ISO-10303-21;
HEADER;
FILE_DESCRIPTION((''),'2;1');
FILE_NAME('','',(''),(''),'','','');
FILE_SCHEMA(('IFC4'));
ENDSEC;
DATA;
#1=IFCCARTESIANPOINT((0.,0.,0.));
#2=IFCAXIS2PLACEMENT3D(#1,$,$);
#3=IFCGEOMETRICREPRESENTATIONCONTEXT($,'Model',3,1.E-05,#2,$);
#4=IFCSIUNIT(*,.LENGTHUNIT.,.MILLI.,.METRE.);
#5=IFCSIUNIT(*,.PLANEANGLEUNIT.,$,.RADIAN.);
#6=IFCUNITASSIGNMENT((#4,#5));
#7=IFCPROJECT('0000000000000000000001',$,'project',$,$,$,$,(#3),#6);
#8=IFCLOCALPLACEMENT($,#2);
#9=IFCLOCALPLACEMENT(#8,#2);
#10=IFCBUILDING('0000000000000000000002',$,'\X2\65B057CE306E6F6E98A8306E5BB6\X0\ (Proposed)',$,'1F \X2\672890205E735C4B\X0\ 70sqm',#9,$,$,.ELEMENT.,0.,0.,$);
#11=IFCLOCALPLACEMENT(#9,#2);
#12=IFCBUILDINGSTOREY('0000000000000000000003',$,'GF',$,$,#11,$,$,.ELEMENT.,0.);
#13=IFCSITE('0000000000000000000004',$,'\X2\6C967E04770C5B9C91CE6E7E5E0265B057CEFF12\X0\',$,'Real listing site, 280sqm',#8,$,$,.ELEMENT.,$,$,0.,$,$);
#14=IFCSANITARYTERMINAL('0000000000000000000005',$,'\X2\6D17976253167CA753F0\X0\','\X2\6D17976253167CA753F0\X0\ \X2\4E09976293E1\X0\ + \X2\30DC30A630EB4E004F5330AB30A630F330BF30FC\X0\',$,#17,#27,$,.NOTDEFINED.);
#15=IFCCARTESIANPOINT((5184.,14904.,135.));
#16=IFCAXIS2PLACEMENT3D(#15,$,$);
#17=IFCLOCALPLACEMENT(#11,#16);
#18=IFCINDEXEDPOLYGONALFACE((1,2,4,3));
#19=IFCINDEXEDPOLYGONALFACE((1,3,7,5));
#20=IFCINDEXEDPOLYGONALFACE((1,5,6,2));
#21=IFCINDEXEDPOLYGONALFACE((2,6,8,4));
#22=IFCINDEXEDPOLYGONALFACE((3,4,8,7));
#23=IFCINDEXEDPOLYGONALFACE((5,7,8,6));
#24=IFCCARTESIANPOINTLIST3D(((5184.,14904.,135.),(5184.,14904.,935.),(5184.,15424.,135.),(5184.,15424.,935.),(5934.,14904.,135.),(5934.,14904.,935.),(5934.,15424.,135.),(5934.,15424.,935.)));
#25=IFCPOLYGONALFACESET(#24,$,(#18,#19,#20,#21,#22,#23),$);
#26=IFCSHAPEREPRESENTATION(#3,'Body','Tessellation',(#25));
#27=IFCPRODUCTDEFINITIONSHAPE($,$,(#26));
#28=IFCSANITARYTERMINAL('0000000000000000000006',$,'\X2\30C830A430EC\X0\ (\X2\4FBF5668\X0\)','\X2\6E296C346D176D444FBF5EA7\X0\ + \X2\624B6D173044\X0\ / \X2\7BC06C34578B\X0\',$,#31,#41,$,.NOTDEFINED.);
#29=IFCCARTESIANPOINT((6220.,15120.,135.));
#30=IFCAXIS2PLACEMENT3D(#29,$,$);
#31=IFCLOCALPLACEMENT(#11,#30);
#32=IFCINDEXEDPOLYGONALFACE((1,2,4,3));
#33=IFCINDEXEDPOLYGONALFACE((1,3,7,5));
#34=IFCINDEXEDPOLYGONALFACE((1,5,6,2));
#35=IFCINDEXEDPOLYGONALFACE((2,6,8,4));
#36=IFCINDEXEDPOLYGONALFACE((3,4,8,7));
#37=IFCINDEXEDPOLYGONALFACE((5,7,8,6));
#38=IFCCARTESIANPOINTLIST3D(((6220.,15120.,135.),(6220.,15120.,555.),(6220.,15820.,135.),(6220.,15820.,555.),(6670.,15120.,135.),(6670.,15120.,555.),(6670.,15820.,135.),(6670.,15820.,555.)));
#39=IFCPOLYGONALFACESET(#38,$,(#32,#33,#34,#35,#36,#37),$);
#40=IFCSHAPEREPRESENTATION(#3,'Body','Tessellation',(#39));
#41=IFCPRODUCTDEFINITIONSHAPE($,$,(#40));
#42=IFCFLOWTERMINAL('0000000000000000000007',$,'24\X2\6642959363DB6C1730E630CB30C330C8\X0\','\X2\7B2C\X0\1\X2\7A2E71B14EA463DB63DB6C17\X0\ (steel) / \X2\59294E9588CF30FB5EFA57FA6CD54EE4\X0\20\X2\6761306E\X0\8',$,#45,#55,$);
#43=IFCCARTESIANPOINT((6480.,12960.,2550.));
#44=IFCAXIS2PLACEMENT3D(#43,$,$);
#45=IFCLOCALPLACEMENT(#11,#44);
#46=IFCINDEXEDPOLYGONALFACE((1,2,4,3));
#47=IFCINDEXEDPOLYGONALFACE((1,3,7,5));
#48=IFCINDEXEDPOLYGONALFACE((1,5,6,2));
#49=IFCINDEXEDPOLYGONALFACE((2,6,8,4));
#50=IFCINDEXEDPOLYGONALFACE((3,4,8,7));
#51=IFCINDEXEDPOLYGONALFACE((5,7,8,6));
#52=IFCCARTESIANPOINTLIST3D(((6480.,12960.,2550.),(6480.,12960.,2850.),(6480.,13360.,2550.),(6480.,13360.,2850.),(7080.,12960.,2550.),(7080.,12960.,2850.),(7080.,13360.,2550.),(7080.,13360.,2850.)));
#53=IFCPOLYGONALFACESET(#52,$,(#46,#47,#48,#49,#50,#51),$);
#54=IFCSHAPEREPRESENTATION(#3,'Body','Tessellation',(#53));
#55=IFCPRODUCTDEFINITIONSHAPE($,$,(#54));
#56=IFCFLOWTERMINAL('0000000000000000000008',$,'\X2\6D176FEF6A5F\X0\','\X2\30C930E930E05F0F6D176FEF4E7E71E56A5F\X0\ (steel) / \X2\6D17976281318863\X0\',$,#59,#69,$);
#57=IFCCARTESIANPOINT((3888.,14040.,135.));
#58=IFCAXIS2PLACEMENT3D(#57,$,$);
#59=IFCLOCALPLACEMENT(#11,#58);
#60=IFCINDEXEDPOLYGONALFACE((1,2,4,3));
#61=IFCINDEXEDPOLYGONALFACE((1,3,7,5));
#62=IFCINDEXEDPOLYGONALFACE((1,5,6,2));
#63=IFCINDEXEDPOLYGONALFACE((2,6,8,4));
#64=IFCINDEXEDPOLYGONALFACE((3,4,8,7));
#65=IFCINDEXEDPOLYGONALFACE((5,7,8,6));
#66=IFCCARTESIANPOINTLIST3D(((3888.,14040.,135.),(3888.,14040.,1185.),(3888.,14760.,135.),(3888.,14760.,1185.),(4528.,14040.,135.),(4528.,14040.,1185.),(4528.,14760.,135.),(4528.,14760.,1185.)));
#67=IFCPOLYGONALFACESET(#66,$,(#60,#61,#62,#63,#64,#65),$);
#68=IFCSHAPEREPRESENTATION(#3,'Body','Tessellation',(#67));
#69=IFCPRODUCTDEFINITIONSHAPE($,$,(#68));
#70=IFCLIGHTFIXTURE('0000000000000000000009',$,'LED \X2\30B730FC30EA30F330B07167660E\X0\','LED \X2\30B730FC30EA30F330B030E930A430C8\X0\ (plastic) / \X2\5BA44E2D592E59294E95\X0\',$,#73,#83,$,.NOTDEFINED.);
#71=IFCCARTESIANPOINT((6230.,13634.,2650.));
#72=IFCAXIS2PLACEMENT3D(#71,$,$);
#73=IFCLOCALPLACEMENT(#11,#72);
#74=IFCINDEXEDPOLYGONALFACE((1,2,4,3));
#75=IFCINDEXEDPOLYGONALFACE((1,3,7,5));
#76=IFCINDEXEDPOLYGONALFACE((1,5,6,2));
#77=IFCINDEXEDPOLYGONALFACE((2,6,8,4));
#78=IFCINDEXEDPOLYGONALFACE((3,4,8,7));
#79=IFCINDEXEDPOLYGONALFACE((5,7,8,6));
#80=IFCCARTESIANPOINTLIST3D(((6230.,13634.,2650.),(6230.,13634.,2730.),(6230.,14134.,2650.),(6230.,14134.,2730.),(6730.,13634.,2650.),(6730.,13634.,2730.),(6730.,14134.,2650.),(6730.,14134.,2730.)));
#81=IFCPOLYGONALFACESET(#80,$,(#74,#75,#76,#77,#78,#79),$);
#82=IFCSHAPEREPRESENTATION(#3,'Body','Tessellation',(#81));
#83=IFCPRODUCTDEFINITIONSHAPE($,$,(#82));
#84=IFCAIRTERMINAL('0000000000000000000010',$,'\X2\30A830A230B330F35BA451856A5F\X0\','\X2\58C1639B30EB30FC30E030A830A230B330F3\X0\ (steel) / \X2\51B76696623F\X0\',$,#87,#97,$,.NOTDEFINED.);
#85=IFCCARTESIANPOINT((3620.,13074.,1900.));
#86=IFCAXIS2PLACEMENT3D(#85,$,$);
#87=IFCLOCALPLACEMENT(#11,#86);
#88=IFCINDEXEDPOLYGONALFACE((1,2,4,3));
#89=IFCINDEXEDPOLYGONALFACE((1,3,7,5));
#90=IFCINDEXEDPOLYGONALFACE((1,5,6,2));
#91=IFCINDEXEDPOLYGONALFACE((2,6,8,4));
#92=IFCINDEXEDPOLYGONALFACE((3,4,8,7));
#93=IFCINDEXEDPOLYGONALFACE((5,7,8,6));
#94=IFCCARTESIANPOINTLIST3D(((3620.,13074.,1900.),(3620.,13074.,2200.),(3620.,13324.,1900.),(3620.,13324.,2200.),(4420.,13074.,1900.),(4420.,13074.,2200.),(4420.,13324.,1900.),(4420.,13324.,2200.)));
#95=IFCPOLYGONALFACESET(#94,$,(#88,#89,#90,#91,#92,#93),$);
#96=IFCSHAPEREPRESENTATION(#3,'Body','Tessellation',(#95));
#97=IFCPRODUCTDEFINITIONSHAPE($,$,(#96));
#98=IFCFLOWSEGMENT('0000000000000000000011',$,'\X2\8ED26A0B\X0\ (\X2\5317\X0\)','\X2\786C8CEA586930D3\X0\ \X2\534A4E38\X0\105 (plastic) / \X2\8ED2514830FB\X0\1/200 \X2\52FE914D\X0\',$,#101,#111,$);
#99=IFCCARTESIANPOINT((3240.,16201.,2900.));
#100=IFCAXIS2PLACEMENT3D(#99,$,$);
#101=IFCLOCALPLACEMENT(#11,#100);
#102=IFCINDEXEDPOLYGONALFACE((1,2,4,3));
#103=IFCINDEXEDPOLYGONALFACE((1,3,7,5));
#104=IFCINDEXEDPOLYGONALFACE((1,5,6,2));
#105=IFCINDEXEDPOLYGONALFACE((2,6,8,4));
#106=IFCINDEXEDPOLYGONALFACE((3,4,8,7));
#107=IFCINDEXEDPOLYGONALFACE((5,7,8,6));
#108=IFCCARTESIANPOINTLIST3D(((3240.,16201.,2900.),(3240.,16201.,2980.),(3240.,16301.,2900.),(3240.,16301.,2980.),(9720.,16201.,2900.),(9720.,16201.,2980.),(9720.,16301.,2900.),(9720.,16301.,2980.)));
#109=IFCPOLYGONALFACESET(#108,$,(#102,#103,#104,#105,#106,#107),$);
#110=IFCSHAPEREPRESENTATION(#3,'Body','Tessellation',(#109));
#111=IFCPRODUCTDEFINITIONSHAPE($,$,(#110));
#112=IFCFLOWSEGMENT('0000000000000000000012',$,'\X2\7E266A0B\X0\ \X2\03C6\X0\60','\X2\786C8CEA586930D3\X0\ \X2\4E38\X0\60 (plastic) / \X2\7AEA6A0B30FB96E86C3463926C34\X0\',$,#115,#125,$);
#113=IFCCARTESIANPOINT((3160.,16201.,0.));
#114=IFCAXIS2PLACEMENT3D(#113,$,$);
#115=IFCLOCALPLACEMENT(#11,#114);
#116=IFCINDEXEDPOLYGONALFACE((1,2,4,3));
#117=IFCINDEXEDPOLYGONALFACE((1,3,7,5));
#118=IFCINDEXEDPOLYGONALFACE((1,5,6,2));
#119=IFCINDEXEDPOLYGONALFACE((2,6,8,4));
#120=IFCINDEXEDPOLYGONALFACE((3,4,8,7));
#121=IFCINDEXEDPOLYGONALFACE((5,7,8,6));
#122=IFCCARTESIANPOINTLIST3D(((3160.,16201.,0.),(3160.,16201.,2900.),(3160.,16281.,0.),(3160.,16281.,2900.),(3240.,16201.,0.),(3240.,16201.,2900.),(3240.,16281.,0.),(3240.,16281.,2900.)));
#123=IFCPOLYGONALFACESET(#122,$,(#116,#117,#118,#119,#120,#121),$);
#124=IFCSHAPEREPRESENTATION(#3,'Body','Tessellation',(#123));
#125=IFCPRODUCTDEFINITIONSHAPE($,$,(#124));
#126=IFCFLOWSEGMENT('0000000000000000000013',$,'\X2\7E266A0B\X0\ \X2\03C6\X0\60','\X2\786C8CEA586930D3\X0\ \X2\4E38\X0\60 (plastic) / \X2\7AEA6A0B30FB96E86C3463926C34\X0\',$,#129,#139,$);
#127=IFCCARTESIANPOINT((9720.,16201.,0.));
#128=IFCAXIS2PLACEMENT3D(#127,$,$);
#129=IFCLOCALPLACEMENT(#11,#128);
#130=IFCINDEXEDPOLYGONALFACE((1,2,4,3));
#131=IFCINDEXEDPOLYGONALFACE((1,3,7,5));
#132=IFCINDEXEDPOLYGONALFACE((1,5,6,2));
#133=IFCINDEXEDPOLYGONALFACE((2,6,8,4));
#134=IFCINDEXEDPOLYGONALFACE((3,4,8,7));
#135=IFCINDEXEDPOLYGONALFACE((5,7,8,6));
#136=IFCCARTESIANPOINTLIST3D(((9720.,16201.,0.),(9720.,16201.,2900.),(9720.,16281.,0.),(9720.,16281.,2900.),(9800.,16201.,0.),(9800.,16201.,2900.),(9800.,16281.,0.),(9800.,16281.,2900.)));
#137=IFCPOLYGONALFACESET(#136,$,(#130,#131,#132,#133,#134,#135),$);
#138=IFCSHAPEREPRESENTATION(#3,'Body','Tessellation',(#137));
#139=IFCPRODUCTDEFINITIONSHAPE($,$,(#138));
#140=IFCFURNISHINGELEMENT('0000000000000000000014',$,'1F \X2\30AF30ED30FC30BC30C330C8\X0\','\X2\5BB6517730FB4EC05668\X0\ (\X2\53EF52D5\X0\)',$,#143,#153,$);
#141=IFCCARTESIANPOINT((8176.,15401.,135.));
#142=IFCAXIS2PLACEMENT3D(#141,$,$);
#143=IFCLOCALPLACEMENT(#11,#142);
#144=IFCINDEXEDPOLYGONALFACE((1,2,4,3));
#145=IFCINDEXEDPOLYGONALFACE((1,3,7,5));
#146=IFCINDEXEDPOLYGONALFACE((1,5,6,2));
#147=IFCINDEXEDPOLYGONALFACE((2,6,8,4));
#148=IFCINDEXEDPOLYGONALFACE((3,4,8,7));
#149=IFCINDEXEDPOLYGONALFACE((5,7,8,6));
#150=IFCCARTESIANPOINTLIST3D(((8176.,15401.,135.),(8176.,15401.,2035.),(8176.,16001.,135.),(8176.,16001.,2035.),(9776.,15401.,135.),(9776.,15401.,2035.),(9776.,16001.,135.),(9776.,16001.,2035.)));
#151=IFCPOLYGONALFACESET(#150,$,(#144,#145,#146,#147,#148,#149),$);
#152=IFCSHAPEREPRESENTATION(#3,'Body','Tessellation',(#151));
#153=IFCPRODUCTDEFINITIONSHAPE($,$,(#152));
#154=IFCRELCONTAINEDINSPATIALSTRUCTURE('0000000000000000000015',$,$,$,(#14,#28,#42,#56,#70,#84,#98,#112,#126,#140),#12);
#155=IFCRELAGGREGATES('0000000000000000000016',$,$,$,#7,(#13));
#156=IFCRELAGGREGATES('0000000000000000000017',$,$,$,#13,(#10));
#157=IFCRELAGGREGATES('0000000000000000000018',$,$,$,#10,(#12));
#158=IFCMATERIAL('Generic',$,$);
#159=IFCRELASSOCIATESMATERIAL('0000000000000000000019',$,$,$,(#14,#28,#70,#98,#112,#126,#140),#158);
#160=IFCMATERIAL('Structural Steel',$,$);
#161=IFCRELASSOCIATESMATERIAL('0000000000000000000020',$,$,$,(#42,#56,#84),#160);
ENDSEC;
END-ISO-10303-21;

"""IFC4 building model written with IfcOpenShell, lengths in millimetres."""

from ifc_helpers import new_model, si_unit, frame, frame_2d, origin, place, context, project, spatial, rectangle, extrude, material, element, save


model = new_model("IFC4")

# Units and contexts
model_context = context("Model", 3, precision=1e-05, world=origin())
ifc_project = project(units=[si_unit("LENGTHUNIT", "METRE", prefix="MILLI"), si_unit("PLANEANGLEUNIT", "RADIAN")], contexts=[model_context])

# Site, building, storey
site_placement = place(None, origin())
site = spatial("IfcSite", under=ifc_project, at=site_placement, Name="沖縄県宜野湾市新城２", ObjectType="Real listing site, 280sqm", CompositionType="ELEMENT", RefElevation=0.0)
building_placement = place(site_placement, origin())
building = spatial("IfcBuilding", under=site, at=building_placement, Name="新城の潮風の家 (Proposed)", ObjectType="1F 木造平屋 70sqm", CompositionType="ELEMENT", ElevationOfRefHeight=0.0, ElevationOfTerrain=0.0)
storey_placement = place(building_placement, origin())
storey = spatial("IfcBuildingStorey", under=building, at=storey_placement, Name="GF", CompositionType="ELEMENT", Elevation=0.0)

# Shared definitions
ifc_material_1 = material(Name="Generic")

# Sanitary terminals
sanitary_terminal_1_placement = place(storey_placement, frame((5184.0, 14904.0, 135.0)))
element("IfcSanitaryTerminal", 1, at=sanitary_terminal_1_placement, inside=storey, material=ifc_material_1, Name="洗面化粧台", Description="洗面化粧台 三面鏡 + ボウル一体カウンター", PredefinedType="NOTDEFINED", context=model_context, shape_type="SweptSolid", body=[
    extrude(rectangle(XDim=750.0, YDim=520.0, at=frame_2d((375.0, 260.0))), frame((5184.0, 14904.0, 135.0)), (0.0, 0.0, 1.0), 800.0),
])
sanitary_terminal_2_placement = place(storey_placement, frame((6220.0, 15120.0, 135.0)))
element("IfcSanitaryTerminal", 2, at=sanitary_terminal_2_placement, inside=storey, material=ifc_material_1, Name="トイレ (便器)", Description="温水洗浄便座 + 手洗い / 節水型", PredefinedType="NOTDEFINED", context=model_context, shape_type="SweptSolid", body=[
    extrude(rectangle(XDim=450.0, YDim=700.0, at=frame_2d((225.0, 350.0))), frame((6220.0, 15120.0, 135.0)), (0.0, 0.0, 1.0), 420.0),
])

# Flow terminals
ifc_material_2 = material(Name="Structural Steel")
flow_terminal_1_placement = place(storey_placement, frame((6480.0, 12960.0, 2550.0)))
element("IfcFlowTerminal", 3, at=flow_terminal_1_placement, inside=storey, material=ifc_material_2, Name="24時間換気ユニット", Description="第1種熱交換換気 (steel) / 天井裏・建基法令20条の8", context=model_context, shape_type="SweptSolid", body=[
    extrude(rectangle(XDim=600.0, YDim=400.0, at=frame_2d((300.0, 200.0))), frame((6480.0, 12960.0, 2550.0)), (0.0, 0.0, 1.0), 300.0),
])
flow_terminal_2_placement = place(storey_placement, frame((3888.0, 14040.0, 135.0)))
element("IfcFlowTerminal", 4, at=flow_terminal_2_placement, inside=storey, material=ifc_material_2, Name="洗濯機", Description="ドラム式洗濯乾燥機 (steel) / 洗面脱衣", context=model_context, shape_type="SweptSolid", body=[
    extrude(rectangle(XDim=640.0, YDim=720.0, at=frame_2d((320.0, 360.0))), frame((3888.0, 14040.0, 135.0)), (0.0, 0.0, 1.0), 1050.0),
])

# Light fixture
light_fixture_placement = place(storey_placement, frame((6230.0, 13634.0, 2650.0)))
element("IfcLightFixture", 5, at=light_fixture_placement, inside=storey, material=ifc_material_1, Name="LED シーリング照明", Description="LED シーリングライト (plastic) / 室中央天井", PredefinedType="NOTDEFINED", context=model_context, shape_type="SweptSolid", body=[
    extrude(rectangle(XDim=500.0, YDim=500.0, at=frame_2d((250.0, 250.0))), frame((6230.0, 13634.0, 2650.0)), (0.0, 0.0, 1.0), 80.0),
])

# Air terminal
air_terminal_placement = place(storey_placement, frame((3620.0, 13074.0, 1900.0)))
element("IfcAirTerminal", 6, at=air_terminal_placement, inside=storey, material=ifc_material_2, Name="エアコン室内機", Description="壁掛ルームエアコン (steel) / 冷暖房", PredefinedType="NOTDEFINED", context=model_context, shape_type="SweptSolid", body=[
    extrude(rectangle(XDim=800.0, YDim=250.0, at=frame_2d((400.0, 125.0))), frame((3620.0, 13074.0, 1900.0)), (0.0, 0.0, 1.0), 300.0),
])

# Flow segments
flow_segment_1_placement = place(storey_placement, frame((3240.0, 16201.0, 2900.0)))
element("IfcFlowSegment", 7, at=flow_segment_1_placement, inside=storey, material=ifc_material_1, Name="軒樋 (北)", Description="硬質塩ビ 半丸105 (plastic) / 軒先・1/200 勾配", context=model_context, shape_type="SweptSolid", body=[
    extrude(rectangle(XDim=6480.0, YDim=100.0, at=frame_2d((3240.0, 50.0))), frame((3240.0, 16201.0, 2900.0)), (0.0, 0.0, 1.0), 80.0),
])
flow_segment_2_placement = place(storey_placement, frame((3160.0, 16201.0, 0.0)))
element("IfcFlowSegment", 8, at=flow_segment_2_placement, inside=storey, material=ifc_material_1, Name="縦樋 φ60", Description="硬質塩ビ 丸60 (plastic) / 竪樋・雨水排水", context=model_context, shape_type="SweptSolid", body=[
    extrude(rectangle(XDim=80.0, YDim=80.0, at=frame_2d((40.0, 40.0))), frame((3160.0, 16201.0, 0.0)), (0.0, 0.0, 1.0), 2900.0),
])
flow_segment_3_placement = place(storey_placement, frame((9720.0, 16201.0, 0.0)))
element("IfcFlowSegment", 9, at=flow_segment_3_placement, inside=storey, material=ifc_material_1, Name="縦樋 φ60", Description="硬質塩ビ 丸60 (plastic) / 竪樋・雨水排水", context=model_context, shape_type="SweptSolid", body=[
    extrude(rectangle(XDim=80.0, YDim=80.0, at=frame_2d((40.0, 40.0))), frame((9720.0, 16201.0, 0.0)), (0.0, 0.0, 1.0), 2900.0),
])

# Furnishing element
furnishing_placement = place(storey_placement, frame((8176.0, 15401.0, 135.0)))
element("IfcFurnishingElement", 10, at=furnishing_placement, inside=storey, material=ifc_material_1, Name="1F クローゼット", Description="家具・什器 (可動)", context=model_context, shape_type="SweptSolid", body=[
    extrude(rectangle(XDim=1600.0, YDim=600.0, at=frame_2d((800.0, 300.0))), frame((8176.0, 15401.0, 135.0)), (0.0, 0.0, 1.0), 1900.0),
])

save(model, "model.ifc")
